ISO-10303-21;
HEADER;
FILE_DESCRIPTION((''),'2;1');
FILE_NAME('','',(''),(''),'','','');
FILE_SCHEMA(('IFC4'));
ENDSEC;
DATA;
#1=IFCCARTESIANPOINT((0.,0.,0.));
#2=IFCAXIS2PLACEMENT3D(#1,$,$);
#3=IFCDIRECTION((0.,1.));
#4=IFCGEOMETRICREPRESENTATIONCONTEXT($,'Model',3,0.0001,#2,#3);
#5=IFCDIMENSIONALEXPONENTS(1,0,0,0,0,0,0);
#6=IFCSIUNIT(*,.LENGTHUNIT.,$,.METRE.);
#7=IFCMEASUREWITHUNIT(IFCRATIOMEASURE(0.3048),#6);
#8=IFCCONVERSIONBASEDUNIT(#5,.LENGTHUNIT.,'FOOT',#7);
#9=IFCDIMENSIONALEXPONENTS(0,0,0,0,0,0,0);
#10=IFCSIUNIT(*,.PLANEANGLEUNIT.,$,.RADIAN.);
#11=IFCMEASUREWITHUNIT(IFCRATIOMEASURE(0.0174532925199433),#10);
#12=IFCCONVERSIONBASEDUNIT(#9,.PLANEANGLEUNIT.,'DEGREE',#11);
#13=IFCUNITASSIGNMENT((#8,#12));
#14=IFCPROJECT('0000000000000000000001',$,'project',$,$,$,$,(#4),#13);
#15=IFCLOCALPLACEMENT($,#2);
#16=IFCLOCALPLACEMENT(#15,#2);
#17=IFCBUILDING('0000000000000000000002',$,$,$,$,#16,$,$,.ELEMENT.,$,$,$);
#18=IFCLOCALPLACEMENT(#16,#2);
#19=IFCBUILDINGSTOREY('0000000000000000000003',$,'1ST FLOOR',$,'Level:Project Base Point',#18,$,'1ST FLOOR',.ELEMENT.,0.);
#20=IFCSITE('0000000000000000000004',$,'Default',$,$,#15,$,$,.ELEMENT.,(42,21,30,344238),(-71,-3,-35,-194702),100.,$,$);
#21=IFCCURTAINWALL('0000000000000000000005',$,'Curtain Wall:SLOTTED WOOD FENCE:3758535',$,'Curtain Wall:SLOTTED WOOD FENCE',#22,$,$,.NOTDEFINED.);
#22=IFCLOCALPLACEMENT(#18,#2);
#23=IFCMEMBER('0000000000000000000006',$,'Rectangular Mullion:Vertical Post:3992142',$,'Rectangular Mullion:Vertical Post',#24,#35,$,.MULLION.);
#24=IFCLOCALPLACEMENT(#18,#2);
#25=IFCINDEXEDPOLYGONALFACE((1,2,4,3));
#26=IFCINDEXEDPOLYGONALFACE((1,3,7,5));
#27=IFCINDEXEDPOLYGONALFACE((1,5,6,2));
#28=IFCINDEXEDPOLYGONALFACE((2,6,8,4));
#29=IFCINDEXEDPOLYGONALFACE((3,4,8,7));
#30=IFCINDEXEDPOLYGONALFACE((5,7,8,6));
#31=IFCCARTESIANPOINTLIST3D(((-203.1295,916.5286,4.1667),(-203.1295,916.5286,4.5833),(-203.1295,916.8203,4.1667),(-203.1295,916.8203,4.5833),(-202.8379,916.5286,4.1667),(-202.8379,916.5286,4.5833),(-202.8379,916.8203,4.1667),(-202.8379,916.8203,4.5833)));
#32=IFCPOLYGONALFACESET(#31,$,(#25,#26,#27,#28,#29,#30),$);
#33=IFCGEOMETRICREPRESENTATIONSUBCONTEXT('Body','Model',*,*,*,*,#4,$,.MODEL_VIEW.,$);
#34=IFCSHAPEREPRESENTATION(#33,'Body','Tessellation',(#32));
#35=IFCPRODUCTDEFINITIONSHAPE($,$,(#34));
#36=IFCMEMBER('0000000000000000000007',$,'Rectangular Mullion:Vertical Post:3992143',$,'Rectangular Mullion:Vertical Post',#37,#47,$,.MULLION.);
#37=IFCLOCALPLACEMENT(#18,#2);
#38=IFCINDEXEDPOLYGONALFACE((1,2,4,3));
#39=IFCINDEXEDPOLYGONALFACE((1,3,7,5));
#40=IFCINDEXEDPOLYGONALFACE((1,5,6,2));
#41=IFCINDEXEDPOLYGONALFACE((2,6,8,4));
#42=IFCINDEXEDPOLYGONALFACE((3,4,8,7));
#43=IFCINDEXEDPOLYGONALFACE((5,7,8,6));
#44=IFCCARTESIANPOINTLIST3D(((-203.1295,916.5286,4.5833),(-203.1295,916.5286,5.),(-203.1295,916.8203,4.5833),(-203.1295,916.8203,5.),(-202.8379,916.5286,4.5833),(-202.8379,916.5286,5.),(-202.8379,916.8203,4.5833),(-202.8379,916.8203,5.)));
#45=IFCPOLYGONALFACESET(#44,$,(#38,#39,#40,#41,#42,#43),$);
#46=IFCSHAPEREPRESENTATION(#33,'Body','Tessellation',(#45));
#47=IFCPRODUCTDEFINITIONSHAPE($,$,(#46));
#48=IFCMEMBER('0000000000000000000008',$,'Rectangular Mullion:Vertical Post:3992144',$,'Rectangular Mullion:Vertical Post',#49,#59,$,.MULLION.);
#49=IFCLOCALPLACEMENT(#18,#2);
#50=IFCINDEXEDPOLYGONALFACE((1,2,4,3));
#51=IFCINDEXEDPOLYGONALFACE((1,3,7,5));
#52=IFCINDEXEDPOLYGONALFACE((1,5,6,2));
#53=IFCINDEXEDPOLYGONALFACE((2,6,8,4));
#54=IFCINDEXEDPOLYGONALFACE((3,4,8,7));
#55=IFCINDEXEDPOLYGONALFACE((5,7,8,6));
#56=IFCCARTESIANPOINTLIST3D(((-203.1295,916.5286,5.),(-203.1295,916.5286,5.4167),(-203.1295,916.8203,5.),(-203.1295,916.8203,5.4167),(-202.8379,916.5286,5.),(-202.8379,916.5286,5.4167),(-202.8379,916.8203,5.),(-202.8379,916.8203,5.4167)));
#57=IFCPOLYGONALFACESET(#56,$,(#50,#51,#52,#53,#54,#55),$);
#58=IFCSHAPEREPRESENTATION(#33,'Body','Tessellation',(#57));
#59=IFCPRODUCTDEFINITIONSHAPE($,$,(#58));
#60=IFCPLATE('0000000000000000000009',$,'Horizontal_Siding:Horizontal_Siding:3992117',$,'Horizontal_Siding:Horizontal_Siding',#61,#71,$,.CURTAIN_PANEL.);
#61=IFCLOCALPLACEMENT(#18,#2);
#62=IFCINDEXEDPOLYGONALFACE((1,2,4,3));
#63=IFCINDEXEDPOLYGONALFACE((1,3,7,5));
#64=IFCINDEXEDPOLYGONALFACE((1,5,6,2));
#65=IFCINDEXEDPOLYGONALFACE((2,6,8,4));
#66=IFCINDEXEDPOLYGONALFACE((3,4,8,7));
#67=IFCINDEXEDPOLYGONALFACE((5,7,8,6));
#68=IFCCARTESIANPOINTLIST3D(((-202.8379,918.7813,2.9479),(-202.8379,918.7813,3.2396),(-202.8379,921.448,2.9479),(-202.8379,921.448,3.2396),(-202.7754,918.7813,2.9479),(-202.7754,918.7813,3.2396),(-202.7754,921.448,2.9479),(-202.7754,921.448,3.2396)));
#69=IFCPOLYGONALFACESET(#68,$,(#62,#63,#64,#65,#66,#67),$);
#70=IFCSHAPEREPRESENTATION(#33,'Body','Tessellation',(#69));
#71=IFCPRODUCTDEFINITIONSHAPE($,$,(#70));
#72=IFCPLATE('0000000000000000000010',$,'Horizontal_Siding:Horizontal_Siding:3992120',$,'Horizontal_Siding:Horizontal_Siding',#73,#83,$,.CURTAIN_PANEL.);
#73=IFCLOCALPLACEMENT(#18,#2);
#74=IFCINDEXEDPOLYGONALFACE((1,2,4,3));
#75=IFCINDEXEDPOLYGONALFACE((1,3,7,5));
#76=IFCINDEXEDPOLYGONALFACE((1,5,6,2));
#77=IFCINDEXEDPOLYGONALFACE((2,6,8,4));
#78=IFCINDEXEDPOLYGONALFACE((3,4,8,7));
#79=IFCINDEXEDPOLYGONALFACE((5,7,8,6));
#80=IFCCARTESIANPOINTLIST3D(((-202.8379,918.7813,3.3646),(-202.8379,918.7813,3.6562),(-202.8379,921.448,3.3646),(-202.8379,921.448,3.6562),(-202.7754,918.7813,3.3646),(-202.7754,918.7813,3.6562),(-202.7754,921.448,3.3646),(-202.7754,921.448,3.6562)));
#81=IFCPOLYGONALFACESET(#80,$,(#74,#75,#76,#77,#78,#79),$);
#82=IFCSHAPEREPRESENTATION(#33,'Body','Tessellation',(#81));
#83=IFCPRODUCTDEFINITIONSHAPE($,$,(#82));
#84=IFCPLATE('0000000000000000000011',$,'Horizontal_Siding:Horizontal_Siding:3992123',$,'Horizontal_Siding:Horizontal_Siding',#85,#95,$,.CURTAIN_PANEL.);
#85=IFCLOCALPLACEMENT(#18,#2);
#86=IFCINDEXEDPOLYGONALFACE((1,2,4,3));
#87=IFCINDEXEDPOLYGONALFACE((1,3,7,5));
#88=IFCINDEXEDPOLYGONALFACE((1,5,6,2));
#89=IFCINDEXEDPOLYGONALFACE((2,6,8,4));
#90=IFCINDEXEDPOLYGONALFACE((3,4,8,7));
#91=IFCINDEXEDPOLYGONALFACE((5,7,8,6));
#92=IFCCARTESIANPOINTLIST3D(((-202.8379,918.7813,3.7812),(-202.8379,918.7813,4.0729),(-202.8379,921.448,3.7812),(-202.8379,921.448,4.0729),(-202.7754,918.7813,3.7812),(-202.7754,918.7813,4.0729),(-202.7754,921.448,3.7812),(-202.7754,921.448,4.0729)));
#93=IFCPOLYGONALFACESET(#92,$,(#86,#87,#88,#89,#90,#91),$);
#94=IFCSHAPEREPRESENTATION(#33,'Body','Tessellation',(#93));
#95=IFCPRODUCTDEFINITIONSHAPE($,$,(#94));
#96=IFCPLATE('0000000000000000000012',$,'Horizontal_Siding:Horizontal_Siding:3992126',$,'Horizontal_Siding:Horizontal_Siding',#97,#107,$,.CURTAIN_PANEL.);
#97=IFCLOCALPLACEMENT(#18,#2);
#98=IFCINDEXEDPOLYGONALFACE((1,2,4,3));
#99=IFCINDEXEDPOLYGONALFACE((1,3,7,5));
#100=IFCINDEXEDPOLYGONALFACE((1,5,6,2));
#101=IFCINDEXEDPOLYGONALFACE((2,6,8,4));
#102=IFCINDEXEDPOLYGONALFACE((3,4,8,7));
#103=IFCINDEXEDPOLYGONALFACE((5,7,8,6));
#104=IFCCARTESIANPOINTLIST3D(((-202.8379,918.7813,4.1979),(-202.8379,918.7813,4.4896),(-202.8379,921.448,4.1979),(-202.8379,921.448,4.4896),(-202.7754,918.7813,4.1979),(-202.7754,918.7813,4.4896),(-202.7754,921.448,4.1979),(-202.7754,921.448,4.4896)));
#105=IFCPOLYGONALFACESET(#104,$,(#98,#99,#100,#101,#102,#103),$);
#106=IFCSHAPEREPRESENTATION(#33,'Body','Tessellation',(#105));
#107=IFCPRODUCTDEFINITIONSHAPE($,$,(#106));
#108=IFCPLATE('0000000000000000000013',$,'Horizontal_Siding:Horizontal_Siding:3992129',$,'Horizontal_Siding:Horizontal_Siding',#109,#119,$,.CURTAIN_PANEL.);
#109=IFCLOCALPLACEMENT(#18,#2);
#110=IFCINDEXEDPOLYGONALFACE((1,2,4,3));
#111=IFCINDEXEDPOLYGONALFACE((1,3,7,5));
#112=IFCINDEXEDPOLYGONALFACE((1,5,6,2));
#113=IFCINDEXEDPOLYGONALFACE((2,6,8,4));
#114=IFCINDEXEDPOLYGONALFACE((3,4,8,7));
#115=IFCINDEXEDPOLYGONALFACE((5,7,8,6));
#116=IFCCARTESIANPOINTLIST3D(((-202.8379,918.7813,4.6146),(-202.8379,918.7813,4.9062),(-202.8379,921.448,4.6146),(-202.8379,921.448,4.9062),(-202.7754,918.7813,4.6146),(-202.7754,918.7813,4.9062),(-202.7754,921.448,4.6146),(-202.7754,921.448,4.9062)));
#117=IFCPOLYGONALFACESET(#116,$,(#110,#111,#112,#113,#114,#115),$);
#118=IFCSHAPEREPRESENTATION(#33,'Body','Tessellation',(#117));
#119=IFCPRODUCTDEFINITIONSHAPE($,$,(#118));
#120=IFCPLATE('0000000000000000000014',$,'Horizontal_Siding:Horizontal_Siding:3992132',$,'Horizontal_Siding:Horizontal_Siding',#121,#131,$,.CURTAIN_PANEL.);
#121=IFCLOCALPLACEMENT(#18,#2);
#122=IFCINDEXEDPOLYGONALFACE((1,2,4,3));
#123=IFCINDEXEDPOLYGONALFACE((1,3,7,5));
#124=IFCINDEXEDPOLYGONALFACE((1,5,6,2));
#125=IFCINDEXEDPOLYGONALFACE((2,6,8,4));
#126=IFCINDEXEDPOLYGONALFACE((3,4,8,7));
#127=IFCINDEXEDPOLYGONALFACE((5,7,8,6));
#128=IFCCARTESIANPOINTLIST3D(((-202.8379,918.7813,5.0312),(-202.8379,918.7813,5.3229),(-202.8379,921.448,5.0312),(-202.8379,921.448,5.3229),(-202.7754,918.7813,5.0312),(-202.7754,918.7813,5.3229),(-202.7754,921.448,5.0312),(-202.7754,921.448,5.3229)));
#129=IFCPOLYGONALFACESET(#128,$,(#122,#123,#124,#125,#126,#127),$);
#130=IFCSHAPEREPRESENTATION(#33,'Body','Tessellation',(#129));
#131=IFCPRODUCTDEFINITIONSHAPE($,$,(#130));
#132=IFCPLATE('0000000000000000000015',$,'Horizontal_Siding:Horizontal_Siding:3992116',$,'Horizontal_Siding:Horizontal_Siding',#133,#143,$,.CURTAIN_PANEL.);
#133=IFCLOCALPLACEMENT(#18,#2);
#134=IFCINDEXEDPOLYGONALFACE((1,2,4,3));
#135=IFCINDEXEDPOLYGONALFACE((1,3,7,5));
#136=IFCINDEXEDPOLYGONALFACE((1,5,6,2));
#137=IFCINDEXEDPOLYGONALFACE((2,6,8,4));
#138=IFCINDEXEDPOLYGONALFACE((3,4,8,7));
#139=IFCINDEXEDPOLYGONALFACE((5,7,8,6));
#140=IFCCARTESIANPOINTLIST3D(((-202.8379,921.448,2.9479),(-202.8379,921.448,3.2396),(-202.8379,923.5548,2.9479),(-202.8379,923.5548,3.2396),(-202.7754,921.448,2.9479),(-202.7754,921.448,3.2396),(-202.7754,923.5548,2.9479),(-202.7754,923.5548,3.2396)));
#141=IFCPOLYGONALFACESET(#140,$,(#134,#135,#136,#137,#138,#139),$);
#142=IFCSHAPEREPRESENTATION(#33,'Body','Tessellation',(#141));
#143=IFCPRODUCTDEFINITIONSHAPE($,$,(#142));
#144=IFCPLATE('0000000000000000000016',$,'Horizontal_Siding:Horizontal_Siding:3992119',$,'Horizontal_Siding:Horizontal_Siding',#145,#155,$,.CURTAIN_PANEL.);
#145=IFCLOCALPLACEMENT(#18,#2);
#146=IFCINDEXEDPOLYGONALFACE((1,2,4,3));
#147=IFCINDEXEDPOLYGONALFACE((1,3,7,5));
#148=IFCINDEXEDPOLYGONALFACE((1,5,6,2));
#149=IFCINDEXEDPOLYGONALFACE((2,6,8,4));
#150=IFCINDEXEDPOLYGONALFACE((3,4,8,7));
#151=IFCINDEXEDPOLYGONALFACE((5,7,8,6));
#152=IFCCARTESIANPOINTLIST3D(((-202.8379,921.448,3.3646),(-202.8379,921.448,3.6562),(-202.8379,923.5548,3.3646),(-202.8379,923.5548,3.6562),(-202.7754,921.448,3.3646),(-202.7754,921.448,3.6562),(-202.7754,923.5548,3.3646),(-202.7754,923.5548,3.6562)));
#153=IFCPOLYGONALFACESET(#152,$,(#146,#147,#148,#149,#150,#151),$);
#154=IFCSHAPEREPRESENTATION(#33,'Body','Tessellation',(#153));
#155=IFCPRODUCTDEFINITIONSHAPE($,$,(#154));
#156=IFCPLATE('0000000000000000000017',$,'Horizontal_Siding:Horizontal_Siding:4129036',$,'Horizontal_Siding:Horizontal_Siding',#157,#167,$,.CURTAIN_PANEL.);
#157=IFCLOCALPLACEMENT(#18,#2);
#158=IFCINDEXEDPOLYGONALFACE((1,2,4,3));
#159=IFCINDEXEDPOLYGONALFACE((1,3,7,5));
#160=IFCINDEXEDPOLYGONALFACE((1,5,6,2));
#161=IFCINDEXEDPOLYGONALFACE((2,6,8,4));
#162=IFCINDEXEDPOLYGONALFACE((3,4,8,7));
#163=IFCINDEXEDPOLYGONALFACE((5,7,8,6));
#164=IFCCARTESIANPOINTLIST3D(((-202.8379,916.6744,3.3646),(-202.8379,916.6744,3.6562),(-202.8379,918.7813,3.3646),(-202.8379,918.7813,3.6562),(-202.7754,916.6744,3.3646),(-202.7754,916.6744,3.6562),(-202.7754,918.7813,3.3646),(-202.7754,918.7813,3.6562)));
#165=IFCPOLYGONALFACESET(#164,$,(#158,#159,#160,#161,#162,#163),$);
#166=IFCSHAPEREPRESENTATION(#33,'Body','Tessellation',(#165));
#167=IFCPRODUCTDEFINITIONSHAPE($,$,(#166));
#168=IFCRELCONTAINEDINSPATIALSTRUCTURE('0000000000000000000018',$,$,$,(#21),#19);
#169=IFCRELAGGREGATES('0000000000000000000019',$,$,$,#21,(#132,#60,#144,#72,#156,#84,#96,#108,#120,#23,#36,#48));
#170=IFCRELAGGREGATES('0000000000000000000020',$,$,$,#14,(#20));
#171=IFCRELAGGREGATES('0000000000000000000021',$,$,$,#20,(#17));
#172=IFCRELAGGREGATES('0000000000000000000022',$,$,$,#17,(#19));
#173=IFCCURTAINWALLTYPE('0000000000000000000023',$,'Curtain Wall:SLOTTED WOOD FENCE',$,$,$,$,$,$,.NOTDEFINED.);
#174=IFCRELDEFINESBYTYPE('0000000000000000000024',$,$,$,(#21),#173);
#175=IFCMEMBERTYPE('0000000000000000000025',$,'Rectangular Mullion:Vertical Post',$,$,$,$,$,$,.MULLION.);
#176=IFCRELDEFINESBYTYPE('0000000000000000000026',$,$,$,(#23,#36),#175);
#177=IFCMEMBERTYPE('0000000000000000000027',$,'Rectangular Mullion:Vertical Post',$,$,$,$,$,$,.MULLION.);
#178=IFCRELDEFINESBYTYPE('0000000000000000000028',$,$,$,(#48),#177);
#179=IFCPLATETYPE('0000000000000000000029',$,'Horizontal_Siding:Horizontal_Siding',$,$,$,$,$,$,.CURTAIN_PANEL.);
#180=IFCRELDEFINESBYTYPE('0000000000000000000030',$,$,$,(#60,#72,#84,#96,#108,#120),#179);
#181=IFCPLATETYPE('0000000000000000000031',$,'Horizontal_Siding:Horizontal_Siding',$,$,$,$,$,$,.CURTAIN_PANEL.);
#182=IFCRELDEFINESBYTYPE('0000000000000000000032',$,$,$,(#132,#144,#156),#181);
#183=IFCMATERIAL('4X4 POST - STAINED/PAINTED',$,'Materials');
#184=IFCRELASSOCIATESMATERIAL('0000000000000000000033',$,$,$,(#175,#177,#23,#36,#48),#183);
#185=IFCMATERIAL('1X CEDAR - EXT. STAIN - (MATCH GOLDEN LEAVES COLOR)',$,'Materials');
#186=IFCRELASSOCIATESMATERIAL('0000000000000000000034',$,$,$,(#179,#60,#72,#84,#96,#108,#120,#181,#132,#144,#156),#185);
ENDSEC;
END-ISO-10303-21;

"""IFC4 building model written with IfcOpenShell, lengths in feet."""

from ifc_helpers import new_model, entity, si_unit, converted_unit, direction, frame, frame_2d, origin, origin_2d_with_axis, place, context, subcontext, project, spatial, rectangle, extrude, source, transform, mapped, material, material_profile, profile_set, profile_usage, type_object, type_shapes, element, aggregate, save


model = new_model("IFC4")

# Units and contexts
model_context = context("Model", 3, precision=0.0001, world=origin(), true_north=direction((0.0, 1.0)))
body_context = subcontext(model_context, "Body", "Model", "MODEL_VIEW")
ifc_project = project(units=[converted_unit("LENGTHUNIT", "FOOT", entity("IfcRatioMeasure", 0.3048), si_unit("LENGTHUNIT", "METRE"), dimensions=[1, 0, 0, 0, 0, 0, 0]), converted_unit("PLANEANGLEUNIT", "DEGREE", entity("IfcRatioMeasure", 0.0174532925199433), si_unit("PLANEANGLEUNIT", "RADIAN"), dimensions=[0, 0, 0, 0, 0, 0, 0])], contexts=[model_context])

# Site, building, storey
site_placement = place(None, origin())
site = spatial("IfcSite", under=ifc_project, at=site_placement, Name="Default", CompositionType="ELEMENT", RefLatitude=(42, 21, 30, 344238), RefLongitude=(-71, -3, -35, -194702), RefElevation=100.0)
building_placement = place(site_placement, origin())
building = spatial("IfcBuilding", under=site, at=building_placement, CompositionType="ELEMENT")
storey_placement = place(building_placement, origin())
storey = spatial("IfcBuildingStorey", under=building, at=storey_placement, Name="1ST FLOOR", ObjectType="Level:Project Base Point", LongName="1ST FLOOR", CompositionType="ELEMENT", Elevation=0.0)

# Curtain wall, members, plates
curtain_wall_type = type_object("IfcCurtainWallType", Name="Curtain Wall:SLOTTED WOOD FENCE", PredefinedType="NOTDEFINED")
curtain_wall_placement = place(storey_placement, origin())
curtain_wall = element("IfcCurtainWall", 1, at=curtain_wall_placement, inside=storey, type_object=curtain_wall_type, Name="Curtain Wall:SLOTTED WOOD FENCE:3758535", ObjectType="Curtain Wall:SLOTTED WOOD FENCE", PredefinedType="NOTDEFINED")
ifc_material_1 = material(Name="4X4 POST - STAINED/PAINTED", Category="Materials")
ifc_material_profile = material_profile(ifc_material_1, rectangle(XDim=0.2917, YDim=0.2917, at=origin_2d_with_axis()), Name="Vertical Post")
ifc_profile_set = profile_set([ifc_material_profile], Name="Vertical Post")
ifc_profile_usage_1 = profile_usage(ifc_profile_set)
member_type_1 = type_object("IfcMemberType", Name="Rectangular Mullion:Vertical Post", PredefinedType="MULLION", material=ifc_profile_set)
shared_shape_1 = source(origin(), body_context, "Body", "SweptSolid", [
    extrude(rectangle(XDim=0.2917, YDim=0.2917, at=frame_2d((0.0, 0.0), x_axis=(1.0, 0.0))), frame((-0.1458, 0.2083, -0.4167), z_axis=(0.0, 0.0, 1.0), x_axis=(0.0, -1.0, 0.0)), (0.0, 0.0, 1.0), 0.4167),
])
type_shapes(member_type_1, [shared_shape_1])
member_1_placement = place(storey_placement, frame((-202.7754, 916.5286, 4.1667), z_axis=(0.0, 0.0, -1.0), x_axis=(0.0, -1.0, 0.0)))
member_1 = element("IfcMember", 2, at=member_1_placement, type_object=member_type_1, material=ifc_profile_usage_1, Name="Rectangular Mullion:Vertical Post:3992142", ObjectType="Rectangular Mullion:Vertical Post", PredefinedType="MULLION", context=body_context, shape_type="MappedRepresentation", body=[
    mapped(shared_shape_1, transform((0.0, 0.0, 0.0), scale=1.0)),
])
ifc_profile_usage_2 = profile_usage(ifc_profile_set)
member_2_placement = place(storey_placement, frame((-202.7754, 916.5286, 4.5833), z_axis=(0.0, 0.0, -1.0), x_axis=(0.0, -1.0, 0.0)))
member_2 = element("IfcMember", 3, at=member_2_placement, type_object=member_type_1, material=ifc_profile_usage_2, Name="Rectangular Mullion:Vertical Post:3992143", ObjectType="Rectangular Mullion:Vertical Post", PredefinedType="MULLION", context=body_context, shape_type="MappedRepresentation", body=[
    mapped(shared_shape_1, transform((0.0, 0.0, 0.0), scale=1.0)),
])
ifc_profile_usage_3 = profile_usage(ifc_profile_set)
member_type_2 = type_object("IfcMemberType", Name="Rectangular Mullion:Vertical Post", PredefinedType="MULLION", material=ifc_profile_set)
shared_shape_2 = source(origin(), body_context, "Body", "SweptSolid", [
    extrude(rectangle(XDim=0.2917, YDim=0.2917, at=frame_2d((0.0, 0.0), x_axis=(1.0, 0.0))), frame((-0.1458, 0.2083, -0.4167), z_axis=(0.0, 0.0, 1.0), x_axis=(0.0, -1.0, 0.0)), (0.0, 0.0, 1.0), 0.4167),
])
type_shapes(member_type_2, [shared_shape_2])
member_3_placement = place(storey_placement, frame((-202.7754, 916.5286, 5.0), z_axis=(0.0, 0.0, -1.0), x_axis=(0.0, -1.0, 0.0)))
member_3 = element("IfcMember", 4, at=member_3_placement, type_object=member_type_2, material=ifc_profile_usage_3, Name="Rectangular Mullion:Vertical Post:3992144", ObjectType="Rectangular Mullion:Vertical Post", PredefinedType="MULLION", context=body_context, shape_type="MappedRepresentation", body=[
    mapped(shared_shape_2, transform((0.0, 0.0, 0.0), scale=1.0)),
])
ifc_material_2 = material(Name="1X CEDAR - EXT. STAIN - (MATCH GOLDEN LEAVES COLOR)", Category="Materials")
plate_type_1 = type_object("IfcPlateType", Name="Horizontal_Siding:Horizontal_Siding", PredefinedType="CURTAIN_PANEL", material=ifc_material_2)
shared_shape_3 = source(origin(), body_context, "Body", "SweptSolid", [
    extrude(rectangle(XDim=0.0625, YDim=2.6667, at=origin_2d_with_axis()), frame((1.3333, 0.0312, 0.0), z_axis=(0.0, 0.0, 1.0), x_axis=(0.0, 1.0, 0.0)), (0.0, 0.0, 1.0), 0.2917),
])
type_shapes(plate_type_1, [shared_shape_3])
plate_1_placement = place(curtain_wall_placement, frame((-202.8379, 921.448, 2.9479), z_axis=(0.0, 0.0, 1.0), x_axis=(0.0, -1.0, 0.0)))
plate_1 = element("IfcPlate", 5, at=plate_1_placement, type_object=plate_type_1, material=ifc_material_2, Name="Horizontal_Siding:Horizontal_Siding:3992117", ObjectType="Horizontal_Siding:Horizontal_Siding", PredefinedType="CURTAIN_PANEL", context=body_context, shape_type="MappedRepresentation", body=[
    mapped(shared_shape_3, transform((0.0, 0.0, 0.0), scale=1.0)),
])
plate_2_placement = place(curtain_wall_placement, frame((-202.8379, 921.448, 3.3646), z_axis=(0.0, 0.0, 1.0), x_axis=(0.0, -1.0, 0.0)))
plate_2 = element("IfcPlate", 6, at=plate_2_placement, type_object=plate_type_1, material=ifc_material_2, Name="Horizontal_Siding:Horizontal_Siding:3992120", ObjectType="Horizontal_Siding:Horizontal_Siding", PredefinedType="CURTAIN_PANEL", context=body_context, shape_type="MappedRepresentation", body=[
    mapped(shared_shape_3, transform((0.0, 0.0, 0.0), scale=1.0)),
])
plate_3_placement = place(curtain_wall_placement, frame((-202.8379, 921.448, 3.7812), z_axis=(0.0, 0.0, 1.0), x_axis=(0.0, -1.0, 0.0)))
plate_3 = element("IfcPlate", 7, at=plate_3_placement, type_object=plate_type_1, material=ifc_material_2, Name="Horizontal_Siding:Horizontal_Siding:3992123", ObjectType="Horizontal_Siding:Horizontal_Siding", PredefinedType="CURTAIN_PANEL", context=body_context, shape_type="MappedRepresentation", body=[
    mapped(shared_shape_3, transform((0.0, 0.0, 0.0), scale=1.0)),
])
plate_4_placement = place(curtain_wall_placement, frame((-202.8379, 921.448, 4.1979), z_axis=(0.0, 0.0, 1.0), x_axis=(0.0, -1.0, 0.0)))
plate_4 = element("IfcPlate", 8, at=plate_4_placement, type_object=plate_type_1, material=ifc_material_2, Name="Horizontal_Siding:Horizontal_Siding:3992126", ObjectType="Horizontal_Siding:Horizontal_Siding", PredefinedType="CURTAIN_PANEL", context=body_context, shape_type="MappedRepresentation", body=[
    mapped(shared_shape_3, transform((0.0, 0.0, 0.0), scale=1.0)),
])
plate_5_placement = place(curtain_wall_placement, frame((-202.8379, 921.448, 4.6146), z_axis=(0.0, 0.0, 1.0), x_axis=(0.0, -1.0, 0.0)))
plate_5 = element("IfcPlate", 9, at=plate_5_placement, type_object=plate_type_1, material=ifc_material_2, Name="Horizontal_Siding:Horizontal_Siding:3992129", ObjectType="Horizontal_Siding:Horizontal_Siding", PredefinedType="CURTAIN_PANEL", context=body_context, shape_type="MappedRepresentation", body=[
    mapped(shared_shape_3, transform((0.0, 0.0, 0.0), scale=1.0)),
])
plate_6_placement = place(curtain_wall_placement, frame((-202.8379, 921.448, 5.0312), z_axis=(0.0, 0.0, 1.0), x_axis=(0.0, -1.0, 0.0)))
plate_6 = element("IfcPlate", 10, at=plate_6_placement, type_object=plate_type_1, material=ifc_material_2, Name="Horizontal_Siding:Horizontal_Siding:3992132", ObjectType="Horizontal_Siding:Horizontal_Siding", PredefinedType="CURTAIN_PANEL", context=body_context, shape_type="MappedRepresentation", body=[
    mapped(shared_shape_3, transform((0.0, 0.0, 0.0), scale=1.0)),
])
plate_type_2 = type_object("IfcPlateType", Name="Horizontal_Siding:Horizontal_Siding", PredefinedType="CURTAIN_PANEL", material=ifc_material_2)
shared_shape_4 = source(origin(), body_context, "Body", "SweptSolid", [
    extrude(rectangle(XDim=0.0625, YDim=2.1069, at=origin_2d_with_axis()), frame((1.0534, 0.0312, 0.0), z_axis=(0.0, 0.0, 1.0), x_axis=(0.0, 1.0, 0.0)), (0.0, 0.0, 1.0), 0.2917),
])
type_shapes(plate_type_2, [shared_shape_4])
plate_7_placement = place(curtain_wall_placement, frame((-202.8379, 923.5548, 2.9479), z_axis=(0.0, 0.0, 1.0), x_axis=(0.0, -1.0, 0.0)))
plate_7 = element("IfcPlate", 11, at=plate_7_placement, type_object=plate_type_2, material=ifc_material_2, Name="Horizontal_Siding:Horizontal_Siding:3992116", ObjectType="Horizontal_Siding:Horizontal_Siding", PredefinedType="CURTAIN_PANEL", context=body_context, shape_type="MappedRepresentation", body=[
    mapped(shared_shape_4, transform((0.0, 0.0, 0.0), scale=1.0)),
])
plate_8_placement = place(curtain_wall_placement, frame((-202.8379, 923.5548, 3.3646), z_axis=(0.0, 0.0, 1.0), x_axis=(0.0, -1.0, 0.0)))
plate_8 = element("IfcPlate", 12, at=plate_8_placement, type_object=plate_type_2, material=ifc_material_2, Name="Horizontal_Siding:Horizontal_Siding:3992119", ObjectType="Horizontal_Siding:Horizontal_Siding", PredefinedType="CURTAIN_PANEL", context=body_context, shape_type="MappedRepresentation", body=[
    mapped(shared_shape_4, transform((0.0, 0.0, 0.0), scale=1.0)),
])
plate_9_placement = place(curtain_wall_placement, frame((-202.8379, 918.7813, 3.3646), z_axis=(0.0, 0.0, 1.0), x_axis=(0.0, -1.0, 0.0)))
plate_9 = element("IfcPlate", 13, at=plate_9_placement, type_object=plate_type_2, material=ifc_material_2, Name="Horizontal_Siding:Horizontal_Siding:4129036", ObjectType="Horizontal_Siding:Horizontal_Siding", PredefinedType="CURTAIN_PANEL", context=body_context, shape_type="MappedRepresentation", body=[
    mapped(shared_shape_4, transform((0.0, 0.0, 0.0), scale=1.0)),
])
aggregate(curtain_wall, [plate_7, plate_1, plate_8, plate_2, plate_9, plate_3, plate_4, plate_5, plate_6, member_1, member_2, member_3])

save(model, "model.ifc")
